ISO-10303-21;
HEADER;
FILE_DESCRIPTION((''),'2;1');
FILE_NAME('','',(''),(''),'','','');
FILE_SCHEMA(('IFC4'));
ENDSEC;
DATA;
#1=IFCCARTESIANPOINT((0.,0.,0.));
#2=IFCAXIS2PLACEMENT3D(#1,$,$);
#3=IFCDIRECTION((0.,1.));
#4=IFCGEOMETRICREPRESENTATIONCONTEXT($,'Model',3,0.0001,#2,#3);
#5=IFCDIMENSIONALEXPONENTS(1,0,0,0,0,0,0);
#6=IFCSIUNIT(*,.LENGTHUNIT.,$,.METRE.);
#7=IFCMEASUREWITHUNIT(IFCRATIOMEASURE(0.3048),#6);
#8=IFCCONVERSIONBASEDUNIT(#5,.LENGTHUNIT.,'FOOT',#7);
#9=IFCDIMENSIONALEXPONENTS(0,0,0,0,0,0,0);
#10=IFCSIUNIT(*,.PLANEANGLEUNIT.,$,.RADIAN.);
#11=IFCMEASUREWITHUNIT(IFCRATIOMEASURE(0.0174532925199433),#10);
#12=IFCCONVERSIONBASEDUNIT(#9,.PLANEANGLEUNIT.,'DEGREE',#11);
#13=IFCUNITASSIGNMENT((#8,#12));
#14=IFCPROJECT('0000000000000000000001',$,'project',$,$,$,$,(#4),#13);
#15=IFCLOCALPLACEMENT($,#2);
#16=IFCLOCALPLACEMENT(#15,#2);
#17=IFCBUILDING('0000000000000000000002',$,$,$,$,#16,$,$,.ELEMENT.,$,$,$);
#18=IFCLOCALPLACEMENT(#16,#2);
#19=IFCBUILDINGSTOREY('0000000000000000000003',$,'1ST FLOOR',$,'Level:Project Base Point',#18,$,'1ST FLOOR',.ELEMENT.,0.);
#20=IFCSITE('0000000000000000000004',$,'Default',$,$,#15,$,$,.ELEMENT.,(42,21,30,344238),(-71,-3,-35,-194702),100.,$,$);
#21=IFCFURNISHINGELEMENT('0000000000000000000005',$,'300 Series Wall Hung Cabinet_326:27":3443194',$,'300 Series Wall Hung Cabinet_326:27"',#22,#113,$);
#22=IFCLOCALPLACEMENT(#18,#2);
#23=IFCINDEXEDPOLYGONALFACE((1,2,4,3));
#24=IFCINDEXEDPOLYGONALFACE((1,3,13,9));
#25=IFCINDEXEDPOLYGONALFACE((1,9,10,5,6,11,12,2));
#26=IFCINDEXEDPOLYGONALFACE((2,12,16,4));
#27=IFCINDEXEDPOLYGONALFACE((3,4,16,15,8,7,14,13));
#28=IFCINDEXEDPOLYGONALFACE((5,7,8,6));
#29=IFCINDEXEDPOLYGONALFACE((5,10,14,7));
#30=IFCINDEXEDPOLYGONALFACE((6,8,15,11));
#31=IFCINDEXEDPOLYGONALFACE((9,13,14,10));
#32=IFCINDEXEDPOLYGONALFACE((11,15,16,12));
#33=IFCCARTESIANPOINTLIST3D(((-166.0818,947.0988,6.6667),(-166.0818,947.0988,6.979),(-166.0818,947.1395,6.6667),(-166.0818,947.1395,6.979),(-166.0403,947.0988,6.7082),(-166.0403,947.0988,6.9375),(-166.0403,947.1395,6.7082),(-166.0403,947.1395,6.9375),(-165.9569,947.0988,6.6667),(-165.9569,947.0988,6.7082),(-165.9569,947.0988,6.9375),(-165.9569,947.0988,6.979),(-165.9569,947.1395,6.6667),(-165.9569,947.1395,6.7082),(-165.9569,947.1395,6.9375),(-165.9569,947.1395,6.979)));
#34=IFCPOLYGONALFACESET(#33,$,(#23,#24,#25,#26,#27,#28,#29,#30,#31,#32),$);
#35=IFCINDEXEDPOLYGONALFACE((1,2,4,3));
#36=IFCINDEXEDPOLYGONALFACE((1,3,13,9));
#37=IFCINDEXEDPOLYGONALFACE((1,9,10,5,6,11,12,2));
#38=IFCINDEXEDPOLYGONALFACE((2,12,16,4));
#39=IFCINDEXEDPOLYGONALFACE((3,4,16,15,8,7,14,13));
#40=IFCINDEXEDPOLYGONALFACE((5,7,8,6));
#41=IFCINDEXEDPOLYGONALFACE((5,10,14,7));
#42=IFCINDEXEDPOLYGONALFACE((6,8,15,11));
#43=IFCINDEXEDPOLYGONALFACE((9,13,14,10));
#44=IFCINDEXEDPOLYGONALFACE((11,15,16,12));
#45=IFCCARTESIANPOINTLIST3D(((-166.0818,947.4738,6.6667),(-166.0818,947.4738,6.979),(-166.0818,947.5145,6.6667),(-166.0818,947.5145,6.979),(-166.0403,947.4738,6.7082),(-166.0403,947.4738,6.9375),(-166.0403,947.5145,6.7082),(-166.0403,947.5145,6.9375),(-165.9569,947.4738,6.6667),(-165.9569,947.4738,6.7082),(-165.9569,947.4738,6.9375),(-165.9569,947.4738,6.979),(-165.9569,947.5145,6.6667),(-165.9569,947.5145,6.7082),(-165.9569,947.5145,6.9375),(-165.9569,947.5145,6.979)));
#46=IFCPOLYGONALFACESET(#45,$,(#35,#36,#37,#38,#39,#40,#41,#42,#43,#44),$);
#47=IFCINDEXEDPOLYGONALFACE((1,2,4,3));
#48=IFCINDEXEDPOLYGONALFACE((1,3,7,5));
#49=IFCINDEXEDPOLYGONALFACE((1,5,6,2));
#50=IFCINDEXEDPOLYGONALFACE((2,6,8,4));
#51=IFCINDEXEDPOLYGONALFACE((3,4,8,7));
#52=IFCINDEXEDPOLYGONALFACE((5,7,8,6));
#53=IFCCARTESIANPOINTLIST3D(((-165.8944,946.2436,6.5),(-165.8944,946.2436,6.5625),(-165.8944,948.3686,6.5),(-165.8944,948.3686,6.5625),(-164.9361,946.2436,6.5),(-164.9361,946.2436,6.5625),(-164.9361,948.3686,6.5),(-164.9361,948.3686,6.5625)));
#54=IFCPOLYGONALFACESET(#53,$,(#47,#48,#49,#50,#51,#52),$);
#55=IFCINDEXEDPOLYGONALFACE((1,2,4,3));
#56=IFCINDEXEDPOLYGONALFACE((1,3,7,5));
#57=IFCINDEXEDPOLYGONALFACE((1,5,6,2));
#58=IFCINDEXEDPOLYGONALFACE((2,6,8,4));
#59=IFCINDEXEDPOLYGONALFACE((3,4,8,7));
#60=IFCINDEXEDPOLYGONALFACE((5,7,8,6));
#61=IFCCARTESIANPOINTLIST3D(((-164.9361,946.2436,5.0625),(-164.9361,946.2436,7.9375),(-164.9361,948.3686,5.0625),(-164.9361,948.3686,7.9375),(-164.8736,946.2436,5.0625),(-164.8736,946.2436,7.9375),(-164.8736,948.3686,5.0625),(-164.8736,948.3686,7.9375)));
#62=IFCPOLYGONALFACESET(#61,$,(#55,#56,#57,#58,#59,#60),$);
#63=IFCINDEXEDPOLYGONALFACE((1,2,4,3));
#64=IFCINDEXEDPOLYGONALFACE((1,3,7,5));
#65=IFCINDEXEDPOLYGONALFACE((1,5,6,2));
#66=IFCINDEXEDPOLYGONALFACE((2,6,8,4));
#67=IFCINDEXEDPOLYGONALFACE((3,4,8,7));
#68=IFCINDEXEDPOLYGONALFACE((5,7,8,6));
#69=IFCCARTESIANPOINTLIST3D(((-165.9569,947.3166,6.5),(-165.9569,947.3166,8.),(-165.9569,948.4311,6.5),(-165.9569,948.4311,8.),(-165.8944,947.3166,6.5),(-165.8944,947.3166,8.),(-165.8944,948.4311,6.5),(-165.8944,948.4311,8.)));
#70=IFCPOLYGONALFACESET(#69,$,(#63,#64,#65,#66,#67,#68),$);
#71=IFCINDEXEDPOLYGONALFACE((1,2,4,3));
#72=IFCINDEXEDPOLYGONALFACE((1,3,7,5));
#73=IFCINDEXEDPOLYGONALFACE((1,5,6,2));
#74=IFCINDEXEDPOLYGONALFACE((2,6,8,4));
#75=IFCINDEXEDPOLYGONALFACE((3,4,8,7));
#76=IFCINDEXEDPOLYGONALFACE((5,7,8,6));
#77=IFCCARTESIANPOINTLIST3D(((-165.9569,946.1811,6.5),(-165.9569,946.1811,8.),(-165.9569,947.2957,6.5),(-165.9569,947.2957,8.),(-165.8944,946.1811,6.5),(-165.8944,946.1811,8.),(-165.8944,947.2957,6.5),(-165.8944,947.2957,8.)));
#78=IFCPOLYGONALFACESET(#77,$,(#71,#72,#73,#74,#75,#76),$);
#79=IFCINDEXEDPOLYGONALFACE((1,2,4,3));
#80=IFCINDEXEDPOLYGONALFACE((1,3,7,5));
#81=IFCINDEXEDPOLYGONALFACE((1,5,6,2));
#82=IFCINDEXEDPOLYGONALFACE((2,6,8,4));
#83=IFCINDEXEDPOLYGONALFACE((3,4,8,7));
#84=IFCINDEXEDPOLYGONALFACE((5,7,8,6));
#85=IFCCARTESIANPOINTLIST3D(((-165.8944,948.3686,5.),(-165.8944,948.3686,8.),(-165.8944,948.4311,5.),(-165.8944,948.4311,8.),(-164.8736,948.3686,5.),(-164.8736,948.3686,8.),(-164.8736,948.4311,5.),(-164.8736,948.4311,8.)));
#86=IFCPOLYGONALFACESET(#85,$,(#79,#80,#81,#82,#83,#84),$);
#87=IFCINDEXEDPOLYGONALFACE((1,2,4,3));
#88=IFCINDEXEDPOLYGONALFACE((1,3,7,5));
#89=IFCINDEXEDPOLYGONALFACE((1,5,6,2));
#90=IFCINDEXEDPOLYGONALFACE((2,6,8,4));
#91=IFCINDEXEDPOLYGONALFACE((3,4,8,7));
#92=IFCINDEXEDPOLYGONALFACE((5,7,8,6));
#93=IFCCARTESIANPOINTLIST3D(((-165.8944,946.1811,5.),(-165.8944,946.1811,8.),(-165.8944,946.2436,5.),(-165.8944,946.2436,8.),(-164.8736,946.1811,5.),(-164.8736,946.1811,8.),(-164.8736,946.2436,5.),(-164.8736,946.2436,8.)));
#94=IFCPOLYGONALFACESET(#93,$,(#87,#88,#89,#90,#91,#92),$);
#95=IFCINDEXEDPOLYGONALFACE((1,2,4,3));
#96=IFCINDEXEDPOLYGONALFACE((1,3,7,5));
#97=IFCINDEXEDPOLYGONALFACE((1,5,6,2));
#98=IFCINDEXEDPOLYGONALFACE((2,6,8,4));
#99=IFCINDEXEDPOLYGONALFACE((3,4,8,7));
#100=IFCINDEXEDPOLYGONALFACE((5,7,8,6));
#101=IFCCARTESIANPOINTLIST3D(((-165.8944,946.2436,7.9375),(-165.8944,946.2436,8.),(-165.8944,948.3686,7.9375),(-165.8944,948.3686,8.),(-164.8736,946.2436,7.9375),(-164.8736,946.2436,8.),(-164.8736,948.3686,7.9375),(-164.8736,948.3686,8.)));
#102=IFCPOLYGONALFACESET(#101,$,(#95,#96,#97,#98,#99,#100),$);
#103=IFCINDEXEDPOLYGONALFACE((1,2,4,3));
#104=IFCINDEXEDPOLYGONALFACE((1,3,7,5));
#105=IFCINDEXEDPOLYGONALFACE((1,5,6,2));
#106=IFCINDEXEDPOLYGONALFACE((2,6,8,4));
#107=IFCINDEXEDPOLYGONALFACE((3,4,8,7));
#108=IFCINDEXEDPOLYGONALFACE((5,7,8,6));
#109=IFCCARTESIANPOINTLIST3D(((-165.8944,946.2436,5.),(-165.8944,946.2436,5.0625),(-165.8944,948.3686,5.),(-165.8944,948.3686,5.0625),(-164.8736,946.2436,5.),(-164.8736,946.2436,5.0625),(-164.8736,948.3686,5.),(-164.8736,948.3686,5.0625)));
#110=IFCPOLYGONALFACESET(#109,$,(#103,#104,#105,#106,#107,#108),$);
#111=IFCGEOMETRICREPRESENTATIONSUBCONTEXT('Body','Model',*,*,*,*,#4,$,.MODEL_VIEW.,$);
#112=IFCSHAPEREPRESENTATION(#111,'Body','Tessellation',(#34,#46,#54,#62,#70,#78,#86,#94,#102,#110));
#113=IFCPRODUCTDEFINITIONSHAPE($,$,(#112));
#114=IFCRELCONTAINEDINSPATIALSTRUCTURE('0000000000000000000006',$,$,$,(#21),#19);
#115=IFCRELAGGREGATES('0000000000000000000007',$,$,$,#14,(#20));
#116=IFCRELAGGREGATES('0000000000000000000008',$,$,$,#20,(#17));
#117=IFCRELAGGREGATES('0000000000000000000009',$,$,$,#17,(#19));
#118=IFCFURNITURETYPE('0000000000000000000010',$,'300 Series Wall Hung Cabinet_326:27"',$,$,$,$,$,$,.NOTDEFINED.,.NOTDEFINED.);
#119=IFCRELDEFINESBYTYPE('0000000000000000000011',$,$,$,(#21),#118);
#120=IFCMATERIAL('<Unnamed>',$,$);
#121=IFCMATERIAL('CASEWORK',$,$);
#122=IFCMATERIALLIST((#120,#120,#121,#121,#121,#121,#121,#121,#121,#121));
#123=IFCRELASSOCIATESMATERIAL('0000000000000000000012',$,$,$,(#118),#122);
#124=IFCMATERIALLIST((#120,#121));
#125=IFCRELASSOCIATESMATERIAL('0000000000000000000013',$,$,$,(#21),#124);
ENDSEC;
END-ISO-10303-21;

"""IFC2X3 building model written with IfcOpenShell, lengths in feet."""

from ifc_helpers import new_model, entity, si_unit, converted_unit, direction, frame, frame_2d, origin, origin_2d_with_axis, place, context, subcontext, project, spatial, polyline, rectangle, outline, extrude, source, transform, mapped, material, material_list, type_object, type_shapes, element, save


model = new_model("IFC2X3")

# Units and contexts
model_context = context("Model", 3, precision=0.0001, world=origin(), true_north=direction((0.0, 1.0)))
body_context = subcontext(model_context, "Body", "Model", "MODEL_VIEW")
ifc_project = project(units=[converted_unit("LENGTHUNIT", "FOOT", entity("IfcRatioMeasure", 0.3048), si_unit("LENGTHUNIT", "METRE"), dimensions=[1, 0, 0, 0, 0, 0, 0]), converted_unit("PLANEANGLEUNIT", "DEGREE", entity("IfcRatioMeasure", 0.0174532925199433), si_unit("PLANEANGLEUNIT", "RADIAN"), dimensions=[0, 0, 0, 0, 0, 0, 0])], contexts=[model_context])

# Site, building, storey
site_placement = place(None, origin())
site = spatial("IfcSite", under=ifc_project, at=site_placement, Name="Default", CompositionType="ELEMENT", RefLatitude=(42, 21, 30, 344238), RefLongitude=(-71, -3, -35, -194702), RefElevation=100.0)
building_placement = place(site_placement, origin())
building = spatial("IfcBuilding", under=site, at=building_placement, CompositionType="ELEMENT")
storey_placement = place(building_placement, origin())
storey = spatial("IfcBuildingStorey", under=building, at=storey_placement, Name="1ST FLOOR", ObjectType="Level:Project Base Point", LongName="1ST FLOOR", CompositionType="ELEMENT", Elevation=0.0)

# Shared definitions
ifc_material_1 = material(Name="CASEWORK")

# Furnishing element
ifc_material_2 = material(Name="<Unnamed>")
ifc_material_list_1 = material_list([ifc_material_2, ifc_material_1])
ifc_material_list_2 = material_list([ifc_material_2, ifc_material_2, ifc_material_1, ifc_material_1, ifc_material_1, ifc_material_1, ifc_material_1, ifc_material_1, ifc_material_1, ifc_material_1])
furniture_type_1 = type_object("IfcFurnitureType", Name="300 Series Wall Hung Cabinet_326:27\"", material=ifc_material_list_2)
shared_shape_1 = source(origin(), body_context, "Body", "SweptSolid", [
    extrude(outline(polyline([(0.1146, -0.0521), (0.1562, -0.0521), (0.1562, 0.0729), (-0.1562, 0.0729), (-0.1562, -0.0521), (-0.1146, -0.0521), (-0.1146, 0.0313), (0.1146, 0.0313), (0.1146, -0.0521)])), frame((1.2917, 0.0729, 1.8229), z_axis=(1.0, 0.0, 0.0), x_axis=(0.0, 0.0, 1.0)), (0.0, 0.0, 1.0), 0.0407),
    extrude(outline(polyline([(0.1146, -0.0521), (0.1562, -0.0521), (0.1562, 0.0729), (-0.1562, 0.0729), (-0.1562, -0.0521), (-0.1146, -0.0521), (-0.1146, 0.0313), (0.1146, 0.0313), (0.1146, -0.0521)])), frame((0.9167, 0.0729, 1.8229), z_axis=(1.0, 0.0, 0.0), x_axis=(0.0, 0.0, 1.0)), (0.0, 0.0, 1.0), 0.0407),
    extrude(rectangle(XDim=0.9583, YDim=2.125, at=origin_2d_with_axis()), frame((1.125, 0.6666, 1.5), z_axis=(0.0, 0.0, 1.0), x_axis=(0.0, 1.0, 0.0)), (0.0, 0.0, 1.0), 0.0625),
    extrude(rectangle(XDim=2.125, YDim=0.0625, at=origin_2d_with_axis()), frame((1.125, 1.177, 0.0625), z_axis=(0.0, 0.0, 1.0), x_axis=(-1.0, 0.0, 0.0)), (0.0, 0.0, 1.0), 2.875),
    extrude(rectangle(XDim=1.1146, YDim=0.0625, at=frame_2d((0.0, 0.0), x_axis=(1.0, 0.0))), frame((0.5573, 0.1562, 1.5), z_axis=(0.0, 0.0, 1.0), x_axis=(-1.0, 0.0, 0.0)), (0.0, 0.0, 1.0), 1.5),
    extrude(rectangle(XDim=1.1146, YDim=0.0625, at=frame_2d((0.0, 0.0), x_axis=(1.0, 0.0))), frame((1.6927, 0.1562, 1.5), z_axis=(0.0, 0.0, 1.0), x_axis=(-1.0, 0.0, 0.0)), (0.0, 0.0, 1.0), 1.5),
    extrude(rectangle(XDim=1.0208, YDim=0.0625, at=frame_2d((0.0, 0.0), x_axis=(1.0, 0.0))), frame((0.0313, 0.6979, 0.0), z_axis=(0.0, 0.0, 1.0), x_axis=(0.0, -1.0, 0.0)), (0.0, 0.0, 1.0), 3.0),
    extrude(rectangle(XDim=1.0208, YDim=0.0625, at=frame_2d((0.0, 0.0), x_axis=(1.0, 0.0))), frame((2.2188, 0.6979, 0.0), z_axis=(0.0, 0.0, 1.0), x_axis=(0.0, -1.0, 0.0)), (0.0, 0.0, 1.0), 3.0),
    extrude(rectangle(XDim=1.0208, YDim=2.125, at=origin_2d_with_axis()), frame((1.125, 0.6979, 2.9375), z_axis=(0.0, 0.0, 1.0), x_axis=(0.0, 1.0, 0.0)), (0.0, 0.0, 1.0), 0.0625),
    extrude(rectangle(XDim=1.0208, YDim=2.125, at=origin_2d_with_axis()), frame((1.125, 0.6979, 0.0), z_axis=(0.0, 0.0, 1.0), x_axis=(0.0, 1.0, 0.0)), (0.0, 0.0, 1.0), 0.0625),
])
type_shapes(furniture_type_1, [shared_shape_1])
furnishing_1_placement = place(storey_placement, frame((-166.0818, 948.4311, 5.0), z_axis=(0.0, 0.0, 1.0), x_axis=(0.0, -1.0, 0.0)))
element("IfcFurnishingElement", 1, at=furnishing_1_placement, inside=storey, type_object=furniture_type_1, material=ifc_material_list_1, Name="300 Series Wall Hung Cabinet_326:27\":3443194", ObjectType="300 Series Wall Hung Cabinet_326:27\"", context=body_context, shape_type="MappedRepresentation", body=[
    mapped(shared_shape_1, transform((0.0, 0.0, 0.0), scale=1.0)),
])

save(model, "model.ifc")
